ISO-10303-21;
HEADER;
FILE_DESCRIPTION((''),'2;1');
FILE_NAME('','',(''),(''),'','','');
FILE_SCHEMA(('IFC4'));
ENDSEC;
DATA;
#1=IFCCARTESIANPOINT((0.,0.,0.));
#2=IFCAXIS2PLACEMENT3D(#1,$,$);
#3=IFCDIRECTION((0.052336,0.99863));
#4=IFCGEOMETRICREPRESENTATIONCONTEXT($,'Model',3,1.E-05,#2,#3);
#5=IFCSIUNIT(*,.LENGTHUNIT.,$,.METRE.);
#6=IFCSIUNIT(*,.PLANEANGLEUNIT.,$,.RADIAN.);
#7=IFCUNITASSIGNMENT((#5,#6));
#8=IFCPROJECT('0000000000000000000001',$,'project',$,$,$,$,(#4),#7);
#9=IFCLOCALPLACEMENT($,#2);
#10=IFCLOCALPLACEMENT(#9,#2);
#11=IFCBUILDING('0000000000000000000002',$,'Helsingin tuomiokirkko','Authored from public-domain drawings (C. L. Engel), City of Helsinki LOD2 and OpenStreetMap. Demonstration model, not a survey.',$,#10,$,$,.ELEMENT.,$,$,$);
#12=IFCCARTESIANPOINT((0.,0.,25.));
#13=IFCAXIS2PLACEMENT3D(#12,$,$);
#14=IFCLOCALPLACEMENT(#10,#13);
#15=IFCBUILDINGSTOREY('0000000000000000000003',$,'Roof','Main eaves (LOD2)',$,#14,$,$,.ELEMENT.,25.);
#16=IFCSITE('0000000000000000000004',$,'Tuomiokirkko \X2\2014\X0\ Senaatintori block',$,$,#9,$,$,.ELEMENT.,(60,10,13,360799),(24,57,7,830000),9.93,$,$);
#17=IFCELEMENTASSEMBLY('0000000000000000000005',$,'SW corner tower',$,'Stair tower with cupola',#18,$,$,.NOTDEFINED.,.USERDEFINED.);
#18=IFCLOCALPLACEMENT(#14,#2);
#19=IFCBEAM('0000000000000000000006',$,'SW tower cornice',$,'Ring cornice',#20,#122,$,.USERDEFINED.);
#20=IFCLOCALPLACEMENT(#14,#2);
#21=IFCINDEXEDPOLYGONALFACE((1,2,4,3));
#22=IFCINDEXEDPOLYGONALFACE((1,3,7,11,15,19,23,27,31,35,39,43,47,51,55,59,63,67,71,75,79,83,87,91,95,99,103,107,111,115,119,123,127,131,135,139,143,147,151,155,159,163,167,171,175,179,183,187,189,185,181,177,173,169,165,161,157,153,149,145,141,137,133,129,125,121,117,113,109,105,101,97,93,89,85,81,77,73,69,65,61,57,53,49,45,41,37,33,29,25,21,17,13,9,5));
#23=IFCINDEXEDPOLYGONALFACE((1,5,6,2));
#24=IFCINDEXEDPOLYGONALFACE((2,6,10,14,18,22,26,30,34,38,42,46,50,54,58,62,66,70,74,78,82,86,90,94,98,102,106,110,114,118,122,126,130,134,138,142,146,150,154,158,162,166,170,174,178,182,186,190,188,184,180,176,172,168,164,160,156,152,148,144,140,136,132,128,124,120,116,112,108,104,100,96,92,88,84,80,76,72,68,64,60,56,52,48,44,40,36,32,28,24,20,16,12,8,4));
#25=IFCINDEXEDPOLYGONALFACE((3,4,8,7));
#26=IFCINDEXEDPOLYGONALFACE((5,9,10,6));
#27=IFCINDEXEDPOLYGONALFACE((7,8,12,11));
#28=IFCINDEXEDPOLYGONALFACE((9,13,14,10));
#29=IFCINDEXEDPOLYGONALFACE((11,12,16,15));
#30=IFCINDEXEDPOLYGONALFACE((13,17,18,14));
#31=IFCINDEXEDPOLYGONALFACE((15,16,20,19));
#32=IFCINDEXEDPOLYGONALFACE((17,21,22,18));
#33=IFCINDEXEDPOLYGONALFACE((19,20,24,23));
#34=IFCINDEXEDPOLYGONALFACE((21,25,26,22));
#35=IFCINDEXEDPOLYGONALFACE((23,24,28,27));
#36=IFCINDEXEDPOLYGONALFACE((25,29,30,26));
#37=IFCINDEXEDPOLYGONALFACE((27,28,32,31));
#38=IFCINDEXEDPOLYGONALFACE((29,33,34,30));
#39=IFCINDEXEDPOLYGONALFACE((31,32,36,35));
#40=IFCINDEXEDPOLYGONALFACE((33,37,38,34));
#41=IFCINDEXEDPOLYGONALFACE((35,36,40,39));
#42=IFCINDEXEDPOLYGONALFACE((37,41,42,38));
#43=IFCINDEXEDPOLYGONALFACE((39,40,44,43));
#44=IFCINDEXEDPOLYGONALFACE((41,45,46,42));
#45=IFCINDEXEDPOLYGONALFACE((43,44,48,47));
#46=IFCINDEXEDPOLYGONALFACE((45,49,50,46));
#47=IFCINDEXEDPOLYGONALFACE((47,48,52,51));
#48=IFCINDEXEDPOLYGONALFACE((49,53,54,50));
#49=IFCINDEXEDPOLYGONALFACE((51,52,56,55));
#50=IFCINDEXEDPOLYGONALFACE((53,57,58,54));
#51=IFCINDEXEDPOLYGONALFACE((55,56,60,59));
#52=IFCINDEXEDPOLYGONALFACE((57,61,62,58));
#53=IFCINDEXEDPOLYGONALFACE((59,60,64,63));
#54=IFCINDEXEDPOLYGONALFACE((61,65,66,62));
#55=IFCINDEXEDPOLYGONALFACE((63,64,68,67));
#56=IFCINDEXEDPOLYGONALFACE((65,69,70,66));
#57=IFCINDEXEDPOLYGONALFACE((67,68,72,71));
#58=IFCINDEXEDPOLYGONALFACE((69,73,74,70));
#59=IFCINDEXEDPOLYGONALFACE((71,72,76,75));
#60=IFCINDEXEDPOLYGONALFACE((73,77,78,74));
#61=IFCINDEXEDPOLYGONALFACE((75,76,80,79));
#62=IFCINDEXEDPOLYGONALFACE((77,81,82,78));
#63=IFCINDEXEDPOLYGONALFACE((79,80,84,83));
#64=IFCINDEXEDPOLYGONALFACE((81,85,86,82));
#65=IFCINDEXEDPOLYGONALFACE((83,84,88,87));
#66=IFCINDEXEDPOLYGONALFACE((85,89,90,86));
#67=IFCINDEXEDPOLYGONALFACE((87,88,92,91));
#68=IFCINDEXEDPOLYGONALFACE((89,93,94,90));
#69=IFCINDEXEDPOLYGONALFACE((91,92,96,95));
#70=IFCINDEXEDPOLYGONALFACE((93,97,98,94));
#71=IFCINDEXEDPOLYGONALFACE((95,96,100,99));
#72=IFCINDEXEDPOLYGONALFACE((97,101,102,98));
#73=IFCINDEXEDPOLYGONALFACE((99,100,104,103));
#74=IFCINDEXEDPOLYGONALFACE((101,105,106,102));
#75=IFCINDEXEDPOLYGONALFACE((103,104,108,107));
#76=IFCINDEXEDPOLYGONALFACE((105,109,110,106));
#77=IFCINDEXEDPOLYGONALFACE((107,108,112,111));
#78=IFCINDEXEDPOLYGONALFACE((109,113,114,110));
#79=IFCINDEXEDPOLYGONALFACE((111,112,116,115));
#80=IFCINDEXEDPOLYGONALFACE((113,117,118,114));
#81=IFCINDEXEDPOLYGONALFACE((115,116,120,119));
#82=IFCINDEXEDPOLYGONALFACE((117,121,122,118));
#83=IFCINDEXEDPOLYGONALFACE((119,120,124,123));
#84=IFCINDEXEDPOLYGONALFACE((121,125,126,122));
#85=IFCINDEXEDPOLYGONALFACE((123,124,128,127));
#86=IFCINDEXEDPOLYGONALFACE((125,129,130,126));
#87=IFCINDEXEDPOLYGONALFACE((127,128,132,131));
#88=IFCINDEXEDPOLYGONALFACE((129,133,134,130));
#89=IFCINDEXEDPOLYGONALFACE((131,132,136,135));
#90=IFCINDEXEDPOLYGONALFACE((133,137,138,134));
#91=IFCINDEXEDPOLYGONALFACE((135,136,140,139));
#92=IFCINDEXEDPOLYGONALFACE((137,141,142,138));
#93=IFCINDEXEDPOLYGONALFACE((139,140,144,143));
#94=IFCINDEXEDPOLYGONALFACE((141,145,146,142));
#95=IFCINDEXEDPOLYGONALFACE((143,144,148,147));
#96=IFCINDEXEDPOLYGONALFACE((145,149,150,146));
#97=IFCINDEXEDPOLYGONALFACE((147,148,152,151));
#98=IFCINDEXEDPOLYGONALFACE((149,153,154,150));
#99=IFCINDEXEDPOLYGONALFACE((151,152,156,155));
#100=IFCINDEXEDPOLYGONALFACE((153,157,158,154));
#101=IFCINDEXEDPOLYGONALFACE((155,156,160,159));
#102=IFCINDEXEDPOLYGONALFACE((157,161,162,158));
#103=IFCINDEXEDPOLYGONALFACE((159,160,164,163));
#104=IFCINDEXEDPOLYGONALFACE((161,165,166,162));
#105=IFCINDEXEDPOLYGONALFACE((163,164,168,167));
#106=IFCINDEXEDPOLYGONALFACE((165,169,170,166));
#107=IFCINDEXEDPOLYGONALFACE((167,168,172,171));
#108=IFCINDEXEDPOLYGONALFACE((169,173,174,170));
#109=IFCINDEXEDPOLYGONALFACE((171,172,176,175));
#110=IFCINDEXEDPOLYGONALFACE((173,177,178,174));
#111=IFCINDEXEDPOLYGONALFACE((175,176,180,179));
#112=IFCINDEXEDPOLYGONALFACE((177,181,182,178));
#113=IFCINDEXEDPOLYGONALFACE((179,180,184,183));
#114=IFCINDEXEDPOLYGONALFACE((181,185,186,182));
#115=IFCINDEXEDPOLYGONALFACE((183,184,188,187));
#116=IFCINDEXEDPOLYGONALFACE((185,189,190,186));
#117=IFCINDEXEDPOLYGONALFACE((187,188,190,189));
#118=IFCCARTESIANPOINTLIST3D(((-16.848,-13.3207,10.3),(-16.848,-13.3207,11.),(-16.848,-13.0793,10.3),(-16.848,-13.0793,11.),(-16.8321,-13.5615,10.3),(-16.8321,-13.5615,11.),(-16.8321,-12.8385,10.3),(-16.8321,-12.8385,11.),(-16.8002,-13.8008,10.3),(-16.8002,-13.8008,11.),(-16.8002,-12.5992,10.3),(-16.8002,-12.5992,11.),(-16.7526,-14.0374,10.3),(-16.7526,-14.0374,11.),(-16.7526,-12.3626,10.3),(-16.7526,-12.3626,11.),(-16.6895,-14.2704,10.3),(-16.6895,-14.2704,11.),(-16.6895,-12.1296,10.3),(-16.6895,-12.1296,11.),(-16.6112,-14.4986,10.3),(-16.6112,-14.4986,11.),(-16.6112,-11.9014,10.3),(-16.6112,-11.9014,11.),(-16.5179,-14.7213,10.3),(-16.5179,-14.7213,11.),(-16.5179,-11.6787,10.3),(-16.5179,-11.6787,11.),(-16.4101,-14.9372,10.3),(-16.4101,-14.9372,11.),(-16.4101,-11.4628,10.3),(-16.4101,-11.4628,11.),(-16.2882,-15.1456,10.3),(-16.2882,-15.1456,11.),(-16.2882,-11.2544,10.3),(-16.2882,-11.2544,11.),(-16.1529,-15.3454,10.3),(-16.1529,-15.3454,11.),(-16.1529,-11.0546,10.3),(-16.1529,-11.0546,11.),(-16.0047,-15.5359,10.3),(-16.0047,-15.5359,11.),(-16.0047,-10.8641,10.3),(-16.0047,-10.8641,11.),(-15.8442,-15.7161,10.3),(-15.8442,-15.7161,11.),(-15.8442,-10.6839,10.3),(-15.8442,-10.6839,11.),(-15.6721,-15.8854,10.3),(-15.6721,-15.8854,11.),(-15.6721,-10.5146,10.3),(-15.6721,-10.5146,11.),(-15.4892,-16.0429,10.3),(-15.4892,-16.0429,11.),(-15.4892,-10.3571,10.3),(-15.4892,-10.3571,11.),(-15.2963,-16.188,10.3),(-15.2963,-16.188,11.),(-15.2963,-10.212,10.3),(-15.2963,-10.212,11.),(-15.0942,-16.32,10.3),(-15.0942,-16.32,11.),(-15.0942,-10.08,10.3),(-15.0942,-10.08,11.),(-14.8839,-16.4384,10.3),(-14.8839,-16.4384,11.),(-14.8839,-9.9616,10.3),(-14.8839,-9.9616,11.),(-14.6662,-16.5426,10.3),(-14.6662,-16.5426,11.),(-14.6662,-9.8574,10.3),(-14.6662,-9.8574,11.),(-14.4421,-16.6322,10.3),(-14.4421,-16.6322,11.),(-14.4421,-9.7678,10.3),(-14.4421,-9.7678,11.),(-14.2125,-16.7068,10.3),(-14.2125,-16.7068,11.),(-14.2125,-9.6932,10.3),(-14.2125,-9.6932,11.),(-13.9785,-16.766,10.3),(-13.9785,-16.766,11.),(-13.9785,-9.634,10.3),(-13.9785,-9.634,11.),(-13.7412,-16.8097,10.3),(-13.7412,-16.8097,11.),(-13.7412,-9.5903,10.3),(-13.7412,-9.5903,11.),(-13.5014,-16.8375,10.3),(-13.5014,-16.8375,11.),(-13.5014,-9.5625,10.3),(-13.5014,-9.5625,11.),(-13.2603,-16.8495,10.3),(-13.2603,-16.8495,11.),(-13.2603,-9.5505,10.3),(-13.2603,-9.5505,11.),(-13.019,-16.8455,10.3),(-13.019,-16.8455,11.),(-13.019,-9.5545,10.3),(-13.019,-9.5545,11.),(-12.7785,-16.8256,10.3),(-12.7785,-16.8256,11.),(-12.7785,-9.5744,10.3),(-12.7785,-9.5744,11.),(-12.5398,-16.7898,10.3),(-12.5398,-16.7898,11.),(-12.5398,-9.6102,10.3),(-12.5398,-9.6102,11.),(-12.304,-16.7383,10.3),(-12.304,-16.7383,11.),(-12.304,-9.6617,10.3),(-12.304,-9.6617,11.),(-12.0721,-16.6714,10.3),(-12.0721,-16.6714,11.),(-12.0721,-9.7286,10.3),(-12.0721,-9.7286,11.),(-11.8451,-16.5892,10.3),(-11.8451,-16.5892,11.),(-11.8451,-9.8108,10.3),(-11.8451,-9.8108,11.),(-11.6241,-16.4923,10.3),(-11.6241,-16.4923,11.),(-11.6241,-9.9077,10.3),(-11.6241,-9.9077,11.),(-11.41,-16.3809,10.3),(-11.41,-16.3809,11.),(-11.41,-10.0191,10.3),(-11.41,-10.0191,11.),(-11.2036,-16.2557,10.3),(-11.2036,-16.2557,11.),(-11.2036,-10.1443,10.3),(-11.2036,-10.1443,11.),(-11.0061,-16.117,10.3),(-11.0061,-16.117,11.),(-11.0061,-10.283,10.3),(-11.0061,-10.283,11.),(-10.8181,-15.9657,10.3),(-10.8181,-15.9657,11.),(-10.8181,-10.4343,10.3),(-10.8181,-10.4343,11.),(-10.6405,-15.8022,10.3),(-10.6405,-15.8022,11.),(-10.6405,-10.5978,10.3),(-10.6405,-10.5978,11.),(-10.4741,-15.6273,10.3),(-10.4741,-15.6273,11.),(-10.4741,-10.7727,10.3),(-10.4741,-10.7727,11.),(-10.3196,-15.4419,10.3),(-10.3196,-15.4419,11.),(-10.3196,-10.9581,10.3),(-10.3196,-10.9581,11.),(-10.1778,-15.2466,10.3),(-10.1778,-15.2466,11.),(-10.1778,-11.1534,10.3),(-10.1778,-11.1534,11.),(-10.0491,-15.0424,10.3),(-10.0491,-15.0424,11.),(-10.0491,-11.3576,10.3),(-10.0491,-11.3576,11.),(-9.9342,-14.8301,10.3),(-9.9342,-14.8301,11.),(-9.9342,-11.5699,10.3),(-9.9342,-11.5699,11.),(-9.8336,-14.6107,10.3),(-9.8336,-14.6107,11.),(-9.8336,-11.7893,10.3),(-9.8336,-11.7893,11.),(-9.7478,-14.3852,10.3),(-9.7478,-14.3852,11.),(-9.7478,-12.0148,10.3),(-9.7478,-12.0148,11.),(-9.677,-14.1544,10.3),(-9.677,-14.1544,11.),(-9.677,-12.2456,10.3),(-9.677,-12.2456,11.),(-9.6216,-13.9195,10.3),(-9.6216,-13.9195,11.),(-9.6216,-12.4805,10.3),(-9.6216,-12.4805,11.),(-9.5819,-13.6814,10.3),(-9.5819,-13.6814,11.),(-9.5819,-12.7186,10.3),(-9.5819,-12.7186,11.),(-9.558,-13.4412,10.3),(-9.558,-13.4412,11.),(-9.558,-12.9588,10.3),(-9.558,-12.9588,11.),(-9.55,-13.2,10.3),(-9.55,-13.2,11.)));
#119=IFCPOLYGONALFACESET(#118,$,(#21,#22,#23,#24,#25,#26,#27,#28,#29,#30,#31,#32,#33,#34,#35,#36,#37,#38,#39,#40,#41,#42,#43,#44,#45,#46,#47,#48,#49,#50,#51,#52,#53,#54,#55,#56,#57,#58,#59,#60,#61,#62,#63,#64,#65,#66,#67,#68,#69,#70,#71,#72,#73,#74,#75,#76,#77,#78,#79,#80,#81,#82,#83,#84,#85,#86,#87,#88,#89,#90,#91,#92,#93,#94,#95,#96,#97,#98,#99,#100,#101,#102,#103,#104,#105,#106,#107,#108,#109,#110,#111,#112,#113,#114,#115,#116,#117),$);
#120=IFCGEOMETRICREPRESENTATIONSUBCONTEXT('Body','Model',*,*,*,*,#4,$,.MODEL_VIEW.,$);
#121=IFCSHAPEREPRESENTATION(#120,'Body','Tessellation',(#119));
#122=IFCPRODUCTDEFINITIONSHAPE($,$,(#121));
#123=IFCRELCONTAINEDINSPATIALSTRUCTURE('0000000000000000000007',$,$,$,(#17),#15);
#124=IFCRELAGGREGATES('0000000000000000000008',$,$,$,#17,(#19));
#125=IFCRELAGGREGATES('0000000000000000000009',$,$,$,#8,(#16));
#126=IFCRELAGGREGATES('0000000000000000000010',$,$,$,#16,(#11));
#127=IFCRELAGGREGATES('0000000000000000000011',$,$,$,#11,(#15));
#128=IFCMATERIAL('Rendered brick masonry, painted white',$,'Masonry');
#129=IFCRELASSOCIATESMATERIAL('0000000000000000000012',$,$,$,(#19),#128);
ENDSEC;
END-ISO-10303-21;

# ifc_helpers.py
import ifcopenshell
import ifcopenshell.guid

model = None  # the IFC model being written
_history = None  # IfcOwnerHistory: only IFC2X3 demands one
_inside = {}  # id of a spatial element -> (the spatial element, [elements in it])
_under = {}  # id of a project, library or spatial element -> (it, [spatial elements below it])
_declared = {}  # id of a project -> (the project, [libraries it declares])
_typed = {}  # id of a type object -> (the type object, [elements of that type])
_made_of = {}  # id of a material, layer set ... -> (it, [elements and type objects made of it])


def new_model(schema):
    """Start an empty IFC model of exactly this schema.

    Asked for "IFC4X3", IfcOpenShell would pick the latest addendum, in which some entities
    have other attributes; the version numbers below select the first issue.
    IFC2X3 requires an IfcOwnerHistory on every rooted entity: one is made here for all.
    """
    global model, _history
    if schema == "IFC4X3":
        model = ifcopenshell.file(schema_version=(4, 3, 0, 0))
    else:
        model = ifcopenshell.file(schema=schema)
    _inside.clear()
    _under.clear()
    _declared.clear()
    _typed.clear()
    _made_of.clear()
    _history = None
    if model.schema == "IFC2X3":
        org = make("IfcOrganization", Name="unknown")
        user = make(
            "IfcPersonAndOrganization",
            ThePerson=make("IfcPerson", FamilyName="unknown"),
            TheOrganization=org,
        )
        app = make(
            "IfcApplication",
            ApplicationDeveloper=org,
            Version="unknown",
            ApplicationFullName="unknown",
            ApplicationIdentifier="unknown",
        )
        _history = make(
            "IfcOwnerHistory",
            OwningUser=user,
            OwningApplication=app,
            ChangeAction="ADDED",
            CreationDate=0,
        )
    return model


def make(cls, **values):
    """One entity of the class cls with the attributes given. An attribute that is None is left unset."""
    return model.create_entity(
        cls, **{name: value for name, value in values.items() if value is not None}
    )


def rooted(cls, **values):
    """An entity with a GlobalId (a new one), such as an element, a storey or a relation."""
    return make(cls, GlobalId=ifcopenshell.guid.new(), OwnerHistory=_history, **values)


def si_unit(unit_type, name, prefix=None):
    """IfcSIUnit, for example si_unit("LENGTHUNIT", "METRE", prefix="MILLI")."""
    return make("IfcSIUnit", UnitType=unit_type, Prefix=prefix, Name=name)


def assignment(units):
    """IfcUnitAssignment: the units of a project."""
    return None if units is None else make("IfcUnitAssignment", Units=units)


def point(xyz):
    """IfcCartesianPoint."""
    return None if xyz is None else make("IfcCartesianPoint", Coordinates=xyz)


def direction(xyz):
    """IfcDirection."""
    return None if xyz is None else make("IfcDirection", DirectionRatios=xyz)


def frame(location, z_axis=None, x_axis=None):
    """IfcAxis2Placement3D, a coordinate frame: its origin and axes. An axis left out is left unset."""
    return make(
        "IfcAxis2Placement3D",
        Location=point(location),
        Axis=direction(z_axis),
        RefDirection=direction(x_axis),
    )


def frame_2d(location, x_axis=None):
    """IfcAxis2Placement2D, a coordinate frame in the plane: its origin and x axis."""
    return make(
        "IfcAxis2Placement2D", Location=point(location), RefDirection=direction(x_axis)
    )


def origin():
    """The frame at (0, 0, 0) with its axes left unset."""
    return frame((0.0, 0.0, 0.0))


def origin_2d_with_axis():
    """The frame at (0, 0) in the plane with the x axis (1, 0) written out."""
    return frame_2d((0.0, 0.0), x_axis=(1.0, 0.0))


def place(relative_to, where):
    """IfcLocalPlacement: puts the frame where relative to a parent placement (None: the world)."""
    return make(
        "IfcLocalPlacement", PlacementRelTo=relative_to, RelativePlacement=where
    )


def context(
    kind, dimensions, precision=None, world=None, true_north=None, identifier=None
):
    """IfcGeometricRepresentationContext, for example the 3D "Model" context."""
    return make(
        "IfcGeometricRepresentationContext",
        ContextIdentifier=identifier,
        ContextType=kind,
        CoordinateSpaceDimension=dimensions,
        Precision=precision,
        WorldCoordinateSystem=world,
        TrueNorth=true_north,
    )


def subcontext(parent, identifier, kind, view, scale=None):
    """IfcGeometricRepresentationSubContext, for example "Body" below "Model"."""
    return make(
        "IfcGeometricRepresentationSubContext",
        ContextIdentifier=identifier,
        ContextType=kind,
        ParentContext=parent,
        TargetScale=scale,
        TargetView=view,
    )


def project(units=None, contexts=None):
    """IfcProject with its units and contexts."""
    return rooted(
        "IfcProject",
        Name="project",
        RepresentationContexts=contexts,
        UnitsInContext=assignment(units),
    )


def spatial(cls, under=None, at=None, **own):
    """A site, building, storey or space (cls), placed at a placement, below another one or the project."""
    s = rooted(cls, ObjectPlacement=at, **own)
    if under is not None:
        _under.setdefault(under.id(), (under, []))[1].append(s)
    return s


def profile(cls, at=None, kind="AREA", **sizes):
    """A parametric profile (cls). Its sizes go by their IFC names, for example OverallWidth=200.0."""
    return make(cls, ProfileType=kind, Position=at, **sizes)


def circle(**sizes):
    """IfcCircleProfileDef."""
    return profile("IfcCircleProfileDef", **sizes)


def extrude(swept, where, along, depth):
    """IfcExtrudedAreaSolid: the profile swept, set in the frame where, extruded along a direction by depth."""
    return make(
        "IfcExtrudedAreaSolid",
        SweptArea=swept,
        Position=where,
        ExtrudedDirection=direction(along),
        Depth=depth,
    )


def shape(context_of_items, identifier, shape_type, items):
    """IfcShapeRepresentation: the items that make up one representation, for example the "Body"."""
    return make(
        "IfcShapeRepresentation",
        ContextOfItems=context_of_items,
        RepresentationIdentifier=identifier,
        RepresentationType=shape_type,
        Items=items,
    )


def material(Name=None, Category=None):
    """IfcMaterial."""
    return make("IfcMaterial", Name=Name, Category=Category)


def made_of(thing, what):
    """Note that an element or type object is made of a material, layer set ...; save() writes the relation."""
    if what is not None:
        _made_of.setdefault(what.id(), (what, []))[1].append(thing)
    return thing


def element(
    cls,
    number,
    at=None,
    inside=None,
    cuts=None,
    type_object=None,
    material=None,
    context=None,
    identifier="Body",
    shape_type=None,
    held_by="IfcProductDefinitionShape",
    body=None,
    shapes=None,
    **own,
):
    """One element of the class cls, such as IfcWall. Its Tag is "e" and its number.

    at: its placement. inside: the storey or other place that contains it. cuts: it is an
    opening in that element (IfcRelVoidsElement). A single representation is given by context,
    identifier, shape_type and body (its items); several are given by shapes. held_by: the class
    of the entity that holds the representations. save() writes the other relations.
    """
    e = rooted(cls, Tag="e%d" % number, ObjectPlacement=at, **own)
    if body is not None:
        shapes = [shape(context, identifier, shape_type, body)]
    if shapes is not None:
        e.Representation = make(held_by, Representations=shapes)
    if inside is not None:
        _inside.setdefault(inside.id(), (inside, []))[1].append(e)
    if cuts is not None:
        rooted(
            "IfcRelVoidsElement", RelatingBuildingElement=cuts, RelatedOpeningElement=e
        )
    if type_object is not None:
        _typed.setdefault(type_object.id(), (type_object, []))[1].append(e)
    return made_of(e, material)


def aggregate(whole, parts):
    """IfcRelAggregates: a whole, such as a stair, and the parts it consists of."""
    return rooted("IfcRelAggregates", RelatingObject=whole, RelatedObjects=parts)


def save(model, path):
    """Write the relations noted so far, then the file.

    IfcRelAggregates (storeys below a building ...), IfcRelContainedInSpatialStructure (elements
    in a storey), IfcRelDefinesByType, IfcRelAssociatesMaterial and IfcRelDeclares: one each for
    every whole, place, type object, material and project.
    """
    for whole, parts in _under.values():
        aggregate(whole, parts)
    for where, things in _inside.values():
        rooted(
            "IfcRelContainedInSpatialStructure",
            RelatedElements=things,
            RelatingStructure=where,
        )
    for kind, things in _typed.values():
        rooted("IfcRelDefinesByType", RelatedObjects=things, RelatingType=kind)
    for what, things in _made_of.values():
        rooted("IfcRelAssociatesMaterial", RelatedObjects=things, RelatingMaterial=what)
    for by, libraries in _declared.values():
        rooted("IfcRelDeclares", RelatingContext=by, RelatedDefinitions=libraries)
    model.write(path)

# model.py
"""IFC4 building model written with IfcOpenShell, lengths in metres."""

from ifc_helpers import new_model, si_unit, direction, frame, origin, origin_2d_with_axis, place, context, subcontext, project, spatial, circle, extrude, material, element, aggregate, save


model = new_model("IFC4")

# Units and contexts
model_context = context("Model", 3, precision=1e-05, world=origin(), true_north=direction((0.052336, 0.99863)))
body_context = subcontext(model_context, "Body", "Model", "MODEL_VIEW")
ifc_project = project(units=[si_unit("LENGTHUNIT", "METRE"), si_unit("PLANEANGLEUNIT", "RADIAN")], contexts=[model_context])

# Site, building, storey
site_placement = place(None, origin())
site = spatial("IfcSite", under=ifc_project, at=site_placement, Name="Tuomiokirkko — Senaatintori block", CompositionType="ELEMENT", RefLatitude=(60, 10, 13, 360799), RefLongitude=(24, 57, 7, 830000), RefElevation=9.93)
building_placement = place(site_placement, origin())
building = spatial("IfcBuilding", under=site, at=building_placement, Name="Helsingin tuomiokirkko", Description="Authored from public-domain drawings (C. L. Engel), City of Helsinki LOD2 and OpenStreetMap. Demonstration model, not a survey.", CompositionType="ELEMENT")
storey_placement = place(building_placement, frame((0.0, 0.0, 25.0)))
storey = spatial("IfcBuildingStorey", under=building, at=storey_placement, Name="Roof", Description="Main eaves (LOD2)", CompositionType="ELEMENT", Elevation=25.0)

# Element assembly
assembly_1_placement = place(building_placement, origin())
assembly_1 = element("IfcElementAssembly", 1, at=assembly_1_placement, inside=storey, Name="SW corner tower", ObjectType="Stair tower with cupola", AssemblyPlace="NOTDEFINED", PredefinedType="USERDEFINED")

# Beam
ifc_material_1 = material(Name="Rendered brick masonry, painted white", Category="Masonry")
beam_1_placement = place(building_placement, origin())
beam_1 = element("IfcBeam", 2, at=beam_1_placement, material=ifc_material_1, Name="SW tower cornice", ObjectType="Ring cornice", PredefinedType="USERDEFINED", context=body_context, shape_type="SweptSolid", body=[
    extrude(circle(Radius=3.65, at=origin_2d_with_axis()), frame((-13.2, -13.2, 35.3)), (0.0, 0.0, 1.0), 0.7),
])

aggregate(assembly_1, [beam_1])

save(model, "model.ifc")
